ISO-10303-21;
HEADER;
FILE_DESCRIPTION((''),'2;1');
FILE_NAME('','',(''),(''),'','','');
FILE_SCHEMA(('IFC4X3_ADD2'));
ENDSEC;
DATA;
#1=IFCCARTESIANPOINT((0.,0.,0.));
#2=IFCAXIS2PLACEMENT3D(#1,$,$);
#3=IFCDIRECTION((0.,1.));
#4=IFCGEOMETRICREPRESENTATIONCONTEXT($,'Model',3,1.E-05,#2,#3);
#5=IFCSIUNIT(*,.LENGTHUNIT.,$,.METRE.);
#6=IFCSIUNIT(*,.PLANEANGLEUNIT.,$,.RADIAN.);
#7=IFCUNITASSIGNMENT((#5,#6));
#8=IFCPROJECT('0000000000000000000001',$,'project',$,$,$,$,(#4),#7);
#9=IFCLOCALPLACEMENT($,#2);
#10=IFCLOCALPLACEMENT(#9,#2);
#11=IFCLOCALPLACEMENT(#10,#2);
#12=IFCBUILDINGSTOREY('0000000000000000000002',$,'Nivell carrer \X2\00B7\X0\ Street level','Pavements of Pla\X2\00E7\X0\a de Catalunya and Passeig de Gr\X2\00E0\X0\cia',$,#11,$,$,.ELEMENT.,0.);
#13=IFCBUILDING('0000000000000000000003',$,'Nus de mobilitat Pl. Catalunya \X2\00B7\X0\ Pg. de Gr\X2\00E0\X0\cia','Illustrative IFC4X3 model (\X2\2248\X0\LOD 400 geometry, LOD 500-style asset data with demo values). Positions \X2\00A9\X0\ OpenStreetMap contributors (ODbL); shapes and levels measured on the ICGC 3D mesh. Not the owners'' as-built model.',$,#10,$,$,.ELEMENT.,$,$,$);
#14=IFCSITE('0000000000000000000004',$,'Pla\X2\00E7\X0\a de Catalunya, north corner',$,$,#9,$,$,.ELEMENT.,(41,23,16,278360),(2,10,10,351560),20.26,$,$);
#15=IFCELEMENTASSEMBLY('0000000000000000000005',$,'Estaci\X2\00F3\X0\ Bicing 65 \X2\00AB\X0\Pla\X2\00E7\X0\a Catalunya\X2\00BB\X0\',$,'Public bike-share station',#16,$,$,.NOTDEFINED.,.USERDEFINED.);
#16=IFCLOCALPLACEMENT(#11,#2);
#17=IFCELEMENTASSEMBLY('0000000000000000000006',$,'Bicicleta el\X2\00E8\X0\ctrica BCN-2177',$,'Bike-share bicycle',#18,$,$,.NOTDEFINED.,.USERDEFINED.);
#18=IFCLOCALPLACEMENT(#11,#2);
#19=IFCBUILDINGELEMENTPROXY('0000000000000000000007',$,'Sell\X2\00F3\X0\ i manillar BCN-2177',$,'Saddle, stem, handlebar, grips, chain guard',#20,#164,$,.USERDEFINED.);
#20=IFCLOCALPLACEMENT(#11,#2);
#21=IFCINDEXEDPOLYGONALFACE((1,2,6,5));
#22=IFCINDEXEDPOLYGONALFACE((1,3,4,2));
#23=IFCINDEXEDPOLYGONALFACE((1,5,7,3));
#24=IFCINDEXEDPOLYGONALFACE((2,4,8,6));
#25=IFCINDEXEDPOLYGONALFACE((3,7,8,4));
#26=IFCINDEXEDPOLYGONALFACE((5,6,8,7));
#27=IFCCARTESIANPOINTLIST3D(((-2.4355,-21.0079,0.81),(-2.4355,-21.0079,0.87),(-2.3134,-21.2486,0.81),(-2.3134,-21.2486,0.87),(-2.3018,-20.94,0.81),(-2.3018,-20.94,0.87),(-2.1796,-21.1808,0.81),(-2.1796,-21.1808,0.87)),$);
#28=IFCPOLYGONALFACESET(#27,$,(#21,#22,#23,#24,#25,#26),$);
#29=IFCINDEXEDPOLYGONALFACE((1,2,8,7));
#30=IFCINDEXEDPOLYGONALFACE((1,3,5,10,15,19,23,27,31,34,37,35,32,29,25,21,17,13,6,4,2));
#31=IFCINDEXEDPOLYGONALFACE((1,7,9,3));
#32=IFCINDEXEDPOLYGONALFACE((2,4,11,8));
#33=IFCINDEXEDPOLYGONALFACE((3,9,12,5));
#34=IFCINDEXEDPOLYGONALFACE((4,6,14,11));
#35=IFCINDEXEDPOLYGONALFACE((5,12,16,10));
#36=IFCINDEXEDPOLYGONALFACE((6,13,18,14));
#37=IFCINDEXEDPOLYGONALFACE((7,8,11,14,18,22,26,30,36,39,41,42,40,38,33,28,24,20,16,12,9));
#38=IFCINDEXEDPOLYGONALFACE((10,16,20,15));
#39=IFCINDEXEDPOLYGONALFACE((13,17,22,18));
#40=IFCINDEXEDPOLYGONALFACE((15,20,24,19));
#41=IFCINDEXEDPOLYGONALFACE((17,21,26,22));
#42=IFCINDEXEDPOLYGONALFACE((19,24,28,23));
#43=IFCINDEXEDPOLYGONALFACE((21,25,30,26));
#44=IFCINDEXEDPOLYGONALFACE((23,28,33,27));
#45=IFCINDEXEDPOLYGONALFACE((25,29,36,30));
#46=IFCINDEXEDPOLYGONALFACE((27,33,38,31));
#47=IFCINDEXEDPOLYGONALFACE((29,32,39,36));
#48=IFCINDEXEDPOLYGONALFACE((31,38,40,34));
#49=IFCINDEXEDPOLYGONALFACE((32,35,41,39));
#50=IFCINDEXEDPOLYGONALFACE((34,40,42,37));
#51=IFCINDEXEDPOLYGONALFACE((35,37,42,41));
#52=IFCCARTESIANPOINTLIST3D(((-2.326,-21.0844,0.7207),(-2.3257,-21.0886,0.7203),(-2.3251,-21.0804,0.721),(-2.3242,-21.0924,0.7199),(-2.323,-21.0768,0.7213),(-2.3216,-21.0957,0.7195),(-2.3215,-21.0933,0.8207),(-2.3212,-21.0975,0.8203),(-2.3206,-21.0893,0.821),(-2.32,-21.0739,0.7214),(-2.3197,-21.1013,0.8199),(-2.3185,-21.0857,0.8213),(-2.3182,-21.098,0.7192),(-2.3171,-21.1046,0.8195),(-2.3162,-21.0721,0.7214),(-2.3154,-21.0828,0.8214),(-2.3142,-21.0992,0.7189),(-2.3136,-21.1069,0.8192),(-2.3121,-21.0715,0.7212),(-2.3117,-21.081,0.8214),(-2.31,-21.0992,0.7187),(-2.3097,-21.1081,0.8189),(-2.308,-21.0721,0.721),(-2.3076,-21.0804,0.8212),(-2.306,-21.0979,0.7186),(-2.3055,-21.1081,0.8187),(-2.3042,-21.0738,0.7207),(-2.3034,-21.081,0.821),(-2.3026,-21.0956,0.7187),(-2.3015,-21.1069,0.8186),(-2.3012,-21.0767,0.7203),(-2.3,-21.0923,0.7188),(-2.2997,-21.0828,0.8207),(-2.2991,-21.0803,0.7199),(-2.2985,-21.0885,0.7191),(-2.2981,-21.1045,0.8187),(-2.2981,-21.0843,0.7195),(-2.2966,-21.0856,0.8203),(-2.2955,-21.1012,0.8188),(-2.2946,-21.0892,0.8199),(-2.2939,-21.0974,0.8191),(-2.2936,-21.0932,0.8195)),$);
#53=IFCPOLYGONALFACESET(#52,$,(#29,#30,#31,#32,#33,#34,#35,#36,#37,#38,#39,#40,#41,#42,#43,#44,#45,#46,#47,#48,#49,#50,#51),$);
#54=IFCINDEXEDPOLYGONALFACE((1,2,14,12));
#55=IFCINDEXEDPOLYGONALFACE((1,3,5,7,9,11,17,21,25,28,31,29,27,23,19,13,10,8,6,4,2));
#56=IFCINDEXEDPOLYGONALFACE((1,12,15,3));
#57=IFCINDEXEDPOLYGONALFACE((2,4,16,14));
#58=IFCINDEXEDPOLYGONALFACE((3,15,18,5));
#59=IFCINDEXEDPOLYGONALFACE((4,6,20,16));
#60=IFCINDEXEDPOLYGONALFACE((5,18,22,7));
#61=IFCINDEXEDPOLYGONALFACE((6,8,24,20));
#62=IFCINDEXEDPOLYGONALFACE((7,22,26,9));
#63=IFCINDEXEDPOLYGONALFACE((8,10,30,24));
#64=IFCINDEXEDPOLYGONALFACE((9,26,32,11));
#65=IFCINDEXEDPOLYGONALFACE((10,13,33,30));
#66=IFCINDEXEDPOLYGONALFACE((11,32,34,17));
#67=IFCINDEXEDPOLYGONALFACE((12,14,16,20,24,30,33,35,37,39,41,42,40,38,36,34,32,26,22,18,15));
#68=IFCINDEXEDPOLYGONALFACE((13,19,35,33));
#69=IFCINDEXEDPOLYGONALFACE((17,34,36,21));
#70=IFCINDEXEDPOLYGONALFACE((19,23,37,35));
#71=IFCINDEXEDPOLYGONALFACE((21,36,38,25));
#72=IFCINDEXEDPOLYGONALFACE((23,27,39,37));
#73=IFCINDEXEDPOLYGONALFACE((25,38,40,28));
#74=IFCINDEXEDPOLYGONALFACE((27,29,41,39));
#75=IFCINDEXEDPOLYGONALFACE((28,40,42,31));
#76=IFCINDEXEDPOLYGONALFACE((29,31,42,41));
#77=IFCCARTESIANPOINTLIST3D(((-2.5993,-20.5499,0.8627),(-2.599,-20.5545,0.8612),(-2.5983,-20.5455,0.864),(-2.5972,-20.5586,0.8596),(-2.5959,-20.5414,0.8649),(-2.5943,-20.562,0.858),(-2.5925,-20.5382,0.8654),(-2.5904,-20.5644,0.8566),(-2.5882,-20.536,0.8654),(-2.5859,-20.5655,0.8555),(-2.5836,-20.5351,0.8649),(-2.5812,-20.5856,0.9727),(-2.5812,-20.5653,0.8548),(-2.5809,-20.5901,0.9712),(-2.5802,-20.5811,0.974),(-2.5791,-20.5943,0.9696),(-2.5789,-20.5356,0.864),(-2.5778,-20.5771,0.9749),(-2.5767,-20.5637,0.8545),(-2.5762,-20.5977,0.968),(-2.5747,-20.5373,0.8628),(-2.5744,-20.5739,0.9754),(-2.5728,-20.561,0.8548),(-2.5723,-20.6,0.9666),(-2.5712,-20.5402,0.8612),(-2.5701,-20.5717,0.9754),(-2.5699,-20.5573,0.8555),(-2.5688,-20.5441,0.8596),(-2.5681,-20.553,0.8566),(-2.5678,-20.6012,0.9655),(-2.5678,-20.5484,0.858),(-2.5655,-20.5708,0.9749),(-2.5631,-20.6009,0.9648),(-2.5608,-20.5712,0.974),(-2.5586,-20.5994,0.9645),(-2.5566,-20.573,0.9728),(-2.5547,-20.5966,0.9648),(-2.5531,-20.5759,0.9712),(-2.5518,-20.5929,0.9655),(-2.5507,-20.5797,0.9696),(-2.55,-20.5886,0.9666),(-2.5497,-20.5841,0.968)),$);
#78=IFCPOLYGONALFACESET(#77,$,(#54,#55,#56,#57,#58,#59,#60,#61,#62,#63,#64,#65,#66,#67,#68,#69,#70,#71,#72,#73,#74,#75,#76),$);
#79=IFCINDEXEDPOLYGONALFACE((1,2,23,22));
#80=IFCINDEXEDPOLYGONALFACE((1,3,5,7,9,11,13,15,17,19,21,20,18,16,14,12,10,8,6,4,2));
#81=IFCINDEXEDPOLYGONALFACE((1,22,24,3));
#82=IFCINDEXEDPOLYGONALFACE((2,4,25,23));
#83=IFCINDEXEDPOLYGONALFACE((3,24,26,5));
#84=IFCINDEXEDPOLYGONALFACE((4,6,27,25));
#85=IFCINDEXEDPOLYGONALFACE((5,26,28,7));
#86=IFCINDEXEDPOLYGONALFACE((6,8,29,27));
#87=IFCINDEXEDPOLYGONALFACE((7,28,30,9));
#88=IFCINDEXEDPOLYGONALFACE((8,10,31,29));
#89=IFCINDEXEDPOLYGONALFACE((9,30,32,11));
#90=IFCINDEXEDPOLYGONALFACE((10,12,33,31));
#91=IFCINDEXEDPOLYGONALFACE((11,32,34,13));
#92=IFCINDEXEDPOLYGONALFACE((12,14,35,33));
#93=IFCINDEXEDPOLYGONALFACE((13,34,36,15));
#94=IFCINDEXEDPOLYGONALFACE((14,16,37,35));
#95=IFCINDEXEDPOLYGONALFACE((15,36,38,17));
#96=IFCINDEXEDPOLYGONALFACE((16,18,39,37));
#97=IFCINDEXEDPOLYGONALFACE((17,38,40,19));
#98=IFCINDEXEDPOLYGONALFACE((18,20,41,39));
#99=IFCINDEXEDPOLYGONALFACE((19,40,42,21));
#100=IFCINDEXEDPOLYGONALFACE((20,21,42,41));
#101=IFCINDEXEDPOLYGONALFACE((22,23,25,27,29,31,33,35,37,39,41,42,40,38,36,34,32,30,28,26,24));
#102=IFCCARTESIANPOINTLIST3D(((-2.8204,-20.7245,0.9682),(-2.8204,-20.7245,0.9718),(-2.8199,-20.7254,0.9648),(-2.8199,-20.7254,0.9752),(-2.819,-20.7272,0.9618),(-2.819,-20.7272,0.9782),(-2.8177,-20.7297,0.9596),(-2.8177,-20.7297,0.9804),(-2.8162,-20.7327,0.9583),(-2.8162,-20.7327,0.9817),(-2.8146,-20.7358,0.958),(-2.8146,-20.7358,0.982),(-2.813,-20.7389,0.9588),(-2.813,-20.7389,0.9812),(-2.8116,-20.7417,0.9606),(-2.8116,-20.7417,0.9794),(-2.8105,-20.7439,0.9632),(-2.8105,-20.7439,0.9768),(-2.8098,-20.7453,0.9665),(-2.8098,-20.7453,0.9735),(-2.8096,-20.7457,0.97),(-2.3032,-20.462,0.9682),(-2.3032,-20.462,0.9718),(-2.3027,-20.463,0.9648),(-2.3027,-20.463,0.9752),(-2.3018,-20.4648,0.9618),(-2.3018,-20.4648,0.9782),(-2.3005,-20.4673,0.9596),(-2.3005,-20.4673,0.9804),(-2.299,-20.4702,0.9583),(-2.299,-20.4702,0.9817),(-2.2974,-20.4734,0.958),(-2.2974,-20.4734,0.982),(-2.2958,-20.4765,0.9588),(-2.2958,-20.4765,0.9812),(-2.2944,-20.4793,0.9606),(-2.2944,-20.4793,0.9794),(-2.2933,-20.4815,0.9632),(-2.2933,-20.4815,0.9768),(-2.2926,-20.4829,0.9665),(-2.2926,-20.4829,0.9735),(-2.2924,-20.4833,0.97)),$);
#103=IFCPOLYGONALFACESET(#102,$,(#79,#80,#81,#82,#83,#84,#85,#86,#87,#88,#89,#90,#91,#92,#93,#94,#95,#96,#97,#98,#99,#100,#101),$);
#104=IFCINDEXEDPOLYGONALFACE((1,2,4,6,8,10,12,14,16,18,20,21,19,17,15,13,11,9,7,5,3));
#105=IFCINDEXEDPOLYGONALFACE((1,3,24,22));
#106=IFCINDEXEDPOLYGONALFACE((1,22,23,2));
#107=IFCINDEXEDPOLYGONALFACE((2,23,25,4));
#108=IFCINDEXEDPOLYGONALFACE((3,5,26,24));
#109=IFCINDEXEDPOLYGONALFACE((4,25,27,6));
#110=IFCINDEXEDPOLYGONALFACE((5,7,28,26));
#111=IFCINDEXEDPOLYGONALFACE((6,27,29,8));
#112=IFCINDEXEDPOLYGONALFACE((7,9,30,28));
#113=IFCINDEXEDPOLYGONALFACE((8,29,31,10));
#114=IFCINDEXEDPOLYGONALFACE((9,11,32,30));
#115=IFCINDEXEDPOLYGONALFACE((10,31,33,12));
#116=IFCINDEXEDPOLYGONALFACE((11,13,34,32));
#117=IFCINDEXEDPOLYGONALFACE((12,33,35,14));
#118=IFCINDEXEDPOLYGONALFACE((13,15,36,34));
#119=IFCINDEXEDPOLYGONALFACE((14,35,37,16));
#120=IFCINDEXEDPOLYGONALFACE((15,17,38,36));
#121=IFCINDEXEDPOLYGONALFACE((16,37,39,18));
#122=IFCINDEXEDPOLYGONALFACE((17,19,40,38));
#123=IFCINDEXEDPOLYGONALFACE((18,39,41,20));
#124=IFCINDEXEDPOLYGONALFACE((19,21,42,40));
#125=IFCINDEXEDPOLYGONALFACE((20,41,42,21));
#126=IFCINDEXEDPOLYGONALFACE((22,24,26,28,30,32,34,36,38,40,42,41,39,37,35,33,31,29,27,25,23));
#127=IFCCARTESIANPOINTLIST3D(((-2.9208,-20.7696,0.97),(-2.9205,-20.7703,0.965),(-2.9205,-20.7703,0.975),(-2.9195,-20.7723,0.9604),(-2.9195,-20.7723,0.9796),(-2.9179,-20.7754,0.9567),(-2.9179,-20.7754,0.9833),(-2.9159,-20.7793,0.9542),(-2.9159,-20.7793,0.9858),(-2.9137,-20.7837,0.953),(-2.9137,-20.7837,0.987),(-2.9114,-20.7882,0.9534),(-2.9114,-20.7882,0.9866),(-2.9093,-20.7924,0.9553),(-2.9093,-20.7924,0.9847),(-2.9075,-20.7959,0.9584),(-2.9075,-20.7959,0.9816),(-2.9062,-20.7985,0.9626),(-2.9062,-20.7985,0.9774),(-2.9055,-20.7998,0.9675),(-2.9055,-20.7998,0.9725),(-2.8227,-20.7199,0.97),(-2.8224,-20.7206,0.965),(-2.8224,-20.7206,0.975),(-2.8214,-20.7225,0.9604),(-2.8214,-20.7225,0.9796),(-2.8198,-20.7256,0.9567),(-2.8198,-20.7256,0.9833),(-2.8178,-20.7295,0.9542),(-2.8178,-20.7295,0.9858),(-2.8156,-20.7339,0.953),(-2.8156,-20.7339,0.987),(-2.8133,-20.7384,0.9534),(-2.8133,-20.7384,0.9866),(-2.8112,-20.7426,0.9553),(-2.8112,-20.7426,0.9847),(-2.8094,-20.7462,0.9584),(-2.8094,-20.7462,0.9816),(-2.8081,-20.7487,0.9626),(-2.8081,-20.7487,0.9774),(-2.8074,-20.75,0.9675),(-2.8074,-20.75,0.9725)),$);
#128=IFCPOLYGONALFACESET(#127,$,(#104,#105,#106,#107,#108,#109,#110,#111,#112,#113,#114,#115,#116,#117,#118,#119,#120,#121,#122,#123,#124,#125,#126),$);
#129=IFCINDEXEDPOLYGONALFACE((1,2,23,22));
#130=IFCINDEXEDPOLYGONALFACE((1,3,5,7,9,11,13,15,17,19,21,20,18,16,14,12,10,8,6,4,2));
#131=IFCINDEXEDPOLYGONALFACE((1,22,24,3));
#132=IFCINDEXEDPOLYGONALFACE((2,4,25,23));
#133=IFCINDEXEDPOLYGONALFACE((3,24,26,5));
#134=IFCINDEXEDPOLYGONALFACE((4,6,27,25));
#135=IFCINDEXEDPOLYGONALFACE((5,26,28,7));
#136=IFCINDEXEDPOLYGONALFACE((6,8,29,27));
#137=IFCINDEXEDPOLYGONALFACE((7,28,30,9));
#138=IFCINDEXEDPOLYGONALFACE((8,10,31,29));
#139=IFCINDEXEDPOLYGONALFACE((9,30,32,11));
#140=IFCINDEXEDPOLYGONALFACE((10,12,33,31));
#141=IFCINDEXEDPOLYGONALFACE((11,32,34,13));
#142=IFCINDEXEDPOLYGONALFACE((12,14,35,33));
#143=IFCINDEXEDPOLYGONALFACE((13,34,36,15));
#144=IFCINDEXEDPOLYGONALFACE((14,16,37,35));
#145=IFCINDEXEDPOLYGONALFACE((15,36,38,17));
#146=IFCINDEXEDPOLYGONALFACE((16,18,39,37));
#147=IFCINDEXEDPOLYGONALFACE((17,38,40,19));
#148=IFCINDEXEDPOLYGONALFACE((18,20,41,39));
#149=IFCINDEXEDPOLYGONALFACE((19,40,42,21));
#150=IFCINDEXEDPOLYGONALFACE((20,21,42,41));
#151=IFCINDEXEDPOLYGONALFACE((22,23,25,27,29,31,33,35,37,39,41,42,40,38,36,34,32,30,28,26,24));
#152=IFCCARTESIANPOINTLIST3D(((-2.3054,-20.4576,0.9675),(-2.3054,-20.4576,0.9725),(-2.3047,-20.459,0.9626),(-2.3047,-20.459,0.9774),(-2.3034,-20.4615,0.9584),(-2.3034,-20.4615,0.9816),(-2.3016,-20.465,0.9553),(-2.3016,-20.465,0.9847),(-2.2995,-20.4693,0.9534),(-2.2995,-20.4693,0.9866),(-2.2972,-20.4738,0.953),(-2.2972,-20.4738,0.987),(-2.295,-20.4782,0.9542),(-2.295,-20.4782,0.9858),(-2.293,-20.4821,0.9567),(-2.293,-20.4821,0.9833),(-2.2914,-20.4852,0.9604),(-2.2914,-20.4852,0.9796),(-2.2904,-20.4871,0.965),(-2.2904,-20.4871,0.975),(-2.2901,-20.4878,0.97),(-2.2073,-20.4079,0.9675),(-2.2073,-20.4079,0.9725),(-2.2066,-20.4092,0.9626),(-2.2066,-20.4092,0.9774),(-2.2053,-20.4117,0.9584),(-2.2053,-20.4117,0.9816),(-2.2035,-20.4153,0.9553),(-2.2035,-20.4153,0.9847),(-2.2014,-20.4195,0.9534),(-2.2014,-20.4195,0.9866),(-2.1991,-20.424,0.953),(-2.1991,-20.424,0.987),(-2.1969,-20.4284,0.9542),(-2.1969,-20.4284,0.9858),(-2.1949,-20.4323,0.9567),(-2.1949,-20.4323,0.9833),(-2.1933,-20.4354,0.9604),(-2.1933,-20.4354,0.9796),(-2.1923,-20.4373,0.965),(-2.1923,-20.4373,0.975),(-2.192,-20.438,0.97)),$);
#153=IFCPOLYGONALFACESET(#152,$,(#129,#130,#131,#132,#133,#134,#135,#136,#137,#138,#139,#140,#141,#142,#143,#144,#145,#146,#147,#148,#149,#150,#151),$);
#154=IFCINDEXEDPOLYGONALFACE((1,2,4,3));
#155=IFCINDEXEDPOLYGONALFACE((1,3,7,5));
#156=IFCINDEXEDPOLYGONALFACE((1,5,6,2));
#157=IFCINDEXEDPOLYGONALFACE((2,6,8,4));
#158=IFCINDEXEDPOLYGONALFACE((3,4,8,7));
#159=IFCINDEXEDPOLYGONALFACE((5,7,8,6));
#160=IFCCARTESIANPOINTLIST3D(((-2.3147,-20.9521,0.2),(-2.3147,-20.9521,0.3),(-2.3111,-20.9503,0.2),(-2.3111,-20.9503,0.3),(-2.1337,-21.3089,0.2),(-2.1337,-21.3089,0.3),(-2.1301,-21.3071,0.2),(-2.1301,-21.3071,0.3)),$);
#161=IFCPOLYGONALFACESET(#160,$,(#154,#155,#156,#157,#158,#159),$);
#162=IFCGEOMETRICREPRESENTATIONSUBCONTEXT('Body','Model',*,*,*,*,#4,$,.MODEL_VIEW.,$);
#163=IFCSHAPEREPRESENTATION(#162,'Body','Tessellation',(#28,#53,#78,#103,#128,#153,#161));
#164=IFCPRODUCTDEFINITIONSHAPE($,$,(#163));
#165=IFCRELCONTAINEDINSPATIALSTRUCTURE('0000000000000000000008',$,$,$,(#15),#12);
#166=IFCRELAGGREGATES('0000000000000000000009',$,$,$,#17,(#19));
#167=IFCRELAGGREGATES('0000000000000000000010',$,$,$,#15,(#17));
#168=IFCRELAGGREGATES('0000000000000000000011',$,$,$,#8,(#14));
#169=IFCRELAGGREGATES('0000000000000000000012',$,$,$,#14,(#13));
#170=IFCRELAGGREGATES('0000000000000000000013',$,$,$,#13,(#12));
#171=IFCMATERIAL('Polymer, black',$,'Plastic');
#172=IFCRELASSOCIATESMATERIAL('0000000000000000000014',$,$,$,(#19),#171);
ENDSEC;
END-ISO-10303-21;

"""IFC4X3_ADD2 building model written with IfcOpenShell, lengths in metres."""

from ifc_helpers import new_model, si_unit, direction, frame, origin, origin_2d_with_axis, place, context, subcontext, project, spatial, rectangle, circle, extrude, material, element, aggregate, save


model = new_model("IFC4X3_ADD2")

# Units and contexts
model_context = context("Model", 3, precision=1e-05, world=origin(), true_north=direction((0.0, 1.0)))
body_context = subcontext(model_context, "Body", "Model", "MODEL_VIEW")
ifc_project = project(units=[si_unit("LENGTHUNIT", "METRE"), si_unit("PLANEANGLEUNIT", "RADIAN")], contexts=[model_context])

# Site, building, storey
site_placement = place(None, origin())
site = spatial("IfcSite", under=ifc_project, at=site_placement, Name="Plaça de Catalunya, north corner", CompositionType="ELEMENT", RefLatitude=(41, 23, 16, 278360), RefLongitude=(2, 10, 10, 351560), RefElevation=20.26)
building_placement = place(site_placement, origin())
building = spatial("IfcBuilding", under=site, at=building_placement, Name="Nus de mobilitat Pl. Catalunya · Pg. de Gràcia", Description="Illustrative IFC4X3 model (≈LOD 400 geometry, LOD 500-style asset data with demo values). Positions © OpenStreetMap contributors (ODbL); shapes and levels measured on the ICGC 3D mesh. Not the owners' as-built model.", CompositionType="ELEMENT")
storey_placement = place(building_placement, origin())
storey = spatial("IfcBuildingStorey", under=building, at=storey_placement, Name="Nivell carrer · Street level", Description="Pavements of Plaça de Catalunya and Passeig de Gràcia", CompositionType="ELEMENT", Elevation=0.0)

# Element assemblies, building element proxy
assembly_1_placement = place(building_placement, origin())
assembly_1 = element("IfcElementAssembly", 1, at=assembly_1_placement, inside=storey, Name="Estació Bicing 65 «Plaça Catalunya»", ObjectType="Public bike-share station", AssemblyPlace="NOTDEFINED", PredefinedType="USERDEFINED")
assembly_2_placement = place(building_placement, origin())
assembly_2 = element("IfcElementAssembly", 2, at=assembly_2_placement, Name="Bicicleta elèctrica BCN-2177", ObjectType="Bike-share bicycle", AssemblyPlace="NOTDEFINED", PredefinedType="USERDEFINED")
ifc_material_1 = material(Name="Polymer, black", Category="Plastic")
proxy_1_placement = place(building_placement, origin())
proxy_1 = element("IfcBuildingElementProxy", 3, at=proxy_1_placement, material=ifc_material_1, Name="Selló i manillar BCN-2177", ObjectType="Saddle, stem, handlebar, grips, chain guard", PredefinedType="USERDEFINED", context=body_context, shape_type="SweptSolid", body=[
    extrude(rectangle(XDim=0.27, YDim=0.15, at=origin_2d_with_axis()), frame((-2.3076, -21.0943, 0.87), z_axis=(0.0, 0.0, -1.0), x_axis=(-0.452435, 0.891798, 0.0)), (0.0, 0.0, 1.0), 0.06),
    extrude(circle(Radius=0.014, at=origin_2d_with_axis()), frame((-2.3121, -21.0854, 0.72), z_axis=(0.045019, -0.088737, 0.995037), x_axis=(0.0, 0.996047, 0.088827)), (0.0, 0.0, 1.0), 0.1005),
    extrude(circle(Radius=0.016, at=origin_2d_with_axis()), frame((-2.5836, -20.5503, 0.86), z_axis=(0.154616, -0.304766, 0.939793), x_axis=(0.0, 0.951232, 0.308475)), (0.0, 0.0, 1.0), 0.117),
    extrude(circle(Radius=0.012, at=origin_2d_with_axis()), frame((-2.815, -20.735, 0.97), z_axis=(0.891798, 0.452435, 0.0), x_axis=(0.452435, -0.891798, 0.0)), (0.0, 0.0, 1.0), 0.58),
    extrude(circle(Radius=0.017, at=origin_2d_with_axis()), frame((-2.815, -20.735, 0.97), z_axis=(-0.891798, -0.452435, 0.0), x_axis=(-0.452435, 0.891798, 0.0)), (0.0, 0.0, 1.0), 0.11),
    extrude(circle(Radius=0.017, at=origin_2d_with_axis()), frame((-2.2978, -20.4726, 0.97), z_axis=(0.891798, 0.452435, 0.0), x_axis=(0.452435, -0.891798, 0.0)), (0.0, 0.0, 1.0), 0.11),
    extrude(rectangle(XDim=0.4, YDim=0.1, at=origin_2d_with_axis()), frame((-2.2242, -21.1305, 0.25), z_axis=(0.891798, 0.452435, 0.0), x_axis=(-0.452435, 0.891798, 0.0)), (0.0, 0.0, 1.0), 0.004),
])
aggregate(assembly_2, [proxy_1])
aggregate(assembly_1, [assembly_2])

save(model, "model.ifc")
